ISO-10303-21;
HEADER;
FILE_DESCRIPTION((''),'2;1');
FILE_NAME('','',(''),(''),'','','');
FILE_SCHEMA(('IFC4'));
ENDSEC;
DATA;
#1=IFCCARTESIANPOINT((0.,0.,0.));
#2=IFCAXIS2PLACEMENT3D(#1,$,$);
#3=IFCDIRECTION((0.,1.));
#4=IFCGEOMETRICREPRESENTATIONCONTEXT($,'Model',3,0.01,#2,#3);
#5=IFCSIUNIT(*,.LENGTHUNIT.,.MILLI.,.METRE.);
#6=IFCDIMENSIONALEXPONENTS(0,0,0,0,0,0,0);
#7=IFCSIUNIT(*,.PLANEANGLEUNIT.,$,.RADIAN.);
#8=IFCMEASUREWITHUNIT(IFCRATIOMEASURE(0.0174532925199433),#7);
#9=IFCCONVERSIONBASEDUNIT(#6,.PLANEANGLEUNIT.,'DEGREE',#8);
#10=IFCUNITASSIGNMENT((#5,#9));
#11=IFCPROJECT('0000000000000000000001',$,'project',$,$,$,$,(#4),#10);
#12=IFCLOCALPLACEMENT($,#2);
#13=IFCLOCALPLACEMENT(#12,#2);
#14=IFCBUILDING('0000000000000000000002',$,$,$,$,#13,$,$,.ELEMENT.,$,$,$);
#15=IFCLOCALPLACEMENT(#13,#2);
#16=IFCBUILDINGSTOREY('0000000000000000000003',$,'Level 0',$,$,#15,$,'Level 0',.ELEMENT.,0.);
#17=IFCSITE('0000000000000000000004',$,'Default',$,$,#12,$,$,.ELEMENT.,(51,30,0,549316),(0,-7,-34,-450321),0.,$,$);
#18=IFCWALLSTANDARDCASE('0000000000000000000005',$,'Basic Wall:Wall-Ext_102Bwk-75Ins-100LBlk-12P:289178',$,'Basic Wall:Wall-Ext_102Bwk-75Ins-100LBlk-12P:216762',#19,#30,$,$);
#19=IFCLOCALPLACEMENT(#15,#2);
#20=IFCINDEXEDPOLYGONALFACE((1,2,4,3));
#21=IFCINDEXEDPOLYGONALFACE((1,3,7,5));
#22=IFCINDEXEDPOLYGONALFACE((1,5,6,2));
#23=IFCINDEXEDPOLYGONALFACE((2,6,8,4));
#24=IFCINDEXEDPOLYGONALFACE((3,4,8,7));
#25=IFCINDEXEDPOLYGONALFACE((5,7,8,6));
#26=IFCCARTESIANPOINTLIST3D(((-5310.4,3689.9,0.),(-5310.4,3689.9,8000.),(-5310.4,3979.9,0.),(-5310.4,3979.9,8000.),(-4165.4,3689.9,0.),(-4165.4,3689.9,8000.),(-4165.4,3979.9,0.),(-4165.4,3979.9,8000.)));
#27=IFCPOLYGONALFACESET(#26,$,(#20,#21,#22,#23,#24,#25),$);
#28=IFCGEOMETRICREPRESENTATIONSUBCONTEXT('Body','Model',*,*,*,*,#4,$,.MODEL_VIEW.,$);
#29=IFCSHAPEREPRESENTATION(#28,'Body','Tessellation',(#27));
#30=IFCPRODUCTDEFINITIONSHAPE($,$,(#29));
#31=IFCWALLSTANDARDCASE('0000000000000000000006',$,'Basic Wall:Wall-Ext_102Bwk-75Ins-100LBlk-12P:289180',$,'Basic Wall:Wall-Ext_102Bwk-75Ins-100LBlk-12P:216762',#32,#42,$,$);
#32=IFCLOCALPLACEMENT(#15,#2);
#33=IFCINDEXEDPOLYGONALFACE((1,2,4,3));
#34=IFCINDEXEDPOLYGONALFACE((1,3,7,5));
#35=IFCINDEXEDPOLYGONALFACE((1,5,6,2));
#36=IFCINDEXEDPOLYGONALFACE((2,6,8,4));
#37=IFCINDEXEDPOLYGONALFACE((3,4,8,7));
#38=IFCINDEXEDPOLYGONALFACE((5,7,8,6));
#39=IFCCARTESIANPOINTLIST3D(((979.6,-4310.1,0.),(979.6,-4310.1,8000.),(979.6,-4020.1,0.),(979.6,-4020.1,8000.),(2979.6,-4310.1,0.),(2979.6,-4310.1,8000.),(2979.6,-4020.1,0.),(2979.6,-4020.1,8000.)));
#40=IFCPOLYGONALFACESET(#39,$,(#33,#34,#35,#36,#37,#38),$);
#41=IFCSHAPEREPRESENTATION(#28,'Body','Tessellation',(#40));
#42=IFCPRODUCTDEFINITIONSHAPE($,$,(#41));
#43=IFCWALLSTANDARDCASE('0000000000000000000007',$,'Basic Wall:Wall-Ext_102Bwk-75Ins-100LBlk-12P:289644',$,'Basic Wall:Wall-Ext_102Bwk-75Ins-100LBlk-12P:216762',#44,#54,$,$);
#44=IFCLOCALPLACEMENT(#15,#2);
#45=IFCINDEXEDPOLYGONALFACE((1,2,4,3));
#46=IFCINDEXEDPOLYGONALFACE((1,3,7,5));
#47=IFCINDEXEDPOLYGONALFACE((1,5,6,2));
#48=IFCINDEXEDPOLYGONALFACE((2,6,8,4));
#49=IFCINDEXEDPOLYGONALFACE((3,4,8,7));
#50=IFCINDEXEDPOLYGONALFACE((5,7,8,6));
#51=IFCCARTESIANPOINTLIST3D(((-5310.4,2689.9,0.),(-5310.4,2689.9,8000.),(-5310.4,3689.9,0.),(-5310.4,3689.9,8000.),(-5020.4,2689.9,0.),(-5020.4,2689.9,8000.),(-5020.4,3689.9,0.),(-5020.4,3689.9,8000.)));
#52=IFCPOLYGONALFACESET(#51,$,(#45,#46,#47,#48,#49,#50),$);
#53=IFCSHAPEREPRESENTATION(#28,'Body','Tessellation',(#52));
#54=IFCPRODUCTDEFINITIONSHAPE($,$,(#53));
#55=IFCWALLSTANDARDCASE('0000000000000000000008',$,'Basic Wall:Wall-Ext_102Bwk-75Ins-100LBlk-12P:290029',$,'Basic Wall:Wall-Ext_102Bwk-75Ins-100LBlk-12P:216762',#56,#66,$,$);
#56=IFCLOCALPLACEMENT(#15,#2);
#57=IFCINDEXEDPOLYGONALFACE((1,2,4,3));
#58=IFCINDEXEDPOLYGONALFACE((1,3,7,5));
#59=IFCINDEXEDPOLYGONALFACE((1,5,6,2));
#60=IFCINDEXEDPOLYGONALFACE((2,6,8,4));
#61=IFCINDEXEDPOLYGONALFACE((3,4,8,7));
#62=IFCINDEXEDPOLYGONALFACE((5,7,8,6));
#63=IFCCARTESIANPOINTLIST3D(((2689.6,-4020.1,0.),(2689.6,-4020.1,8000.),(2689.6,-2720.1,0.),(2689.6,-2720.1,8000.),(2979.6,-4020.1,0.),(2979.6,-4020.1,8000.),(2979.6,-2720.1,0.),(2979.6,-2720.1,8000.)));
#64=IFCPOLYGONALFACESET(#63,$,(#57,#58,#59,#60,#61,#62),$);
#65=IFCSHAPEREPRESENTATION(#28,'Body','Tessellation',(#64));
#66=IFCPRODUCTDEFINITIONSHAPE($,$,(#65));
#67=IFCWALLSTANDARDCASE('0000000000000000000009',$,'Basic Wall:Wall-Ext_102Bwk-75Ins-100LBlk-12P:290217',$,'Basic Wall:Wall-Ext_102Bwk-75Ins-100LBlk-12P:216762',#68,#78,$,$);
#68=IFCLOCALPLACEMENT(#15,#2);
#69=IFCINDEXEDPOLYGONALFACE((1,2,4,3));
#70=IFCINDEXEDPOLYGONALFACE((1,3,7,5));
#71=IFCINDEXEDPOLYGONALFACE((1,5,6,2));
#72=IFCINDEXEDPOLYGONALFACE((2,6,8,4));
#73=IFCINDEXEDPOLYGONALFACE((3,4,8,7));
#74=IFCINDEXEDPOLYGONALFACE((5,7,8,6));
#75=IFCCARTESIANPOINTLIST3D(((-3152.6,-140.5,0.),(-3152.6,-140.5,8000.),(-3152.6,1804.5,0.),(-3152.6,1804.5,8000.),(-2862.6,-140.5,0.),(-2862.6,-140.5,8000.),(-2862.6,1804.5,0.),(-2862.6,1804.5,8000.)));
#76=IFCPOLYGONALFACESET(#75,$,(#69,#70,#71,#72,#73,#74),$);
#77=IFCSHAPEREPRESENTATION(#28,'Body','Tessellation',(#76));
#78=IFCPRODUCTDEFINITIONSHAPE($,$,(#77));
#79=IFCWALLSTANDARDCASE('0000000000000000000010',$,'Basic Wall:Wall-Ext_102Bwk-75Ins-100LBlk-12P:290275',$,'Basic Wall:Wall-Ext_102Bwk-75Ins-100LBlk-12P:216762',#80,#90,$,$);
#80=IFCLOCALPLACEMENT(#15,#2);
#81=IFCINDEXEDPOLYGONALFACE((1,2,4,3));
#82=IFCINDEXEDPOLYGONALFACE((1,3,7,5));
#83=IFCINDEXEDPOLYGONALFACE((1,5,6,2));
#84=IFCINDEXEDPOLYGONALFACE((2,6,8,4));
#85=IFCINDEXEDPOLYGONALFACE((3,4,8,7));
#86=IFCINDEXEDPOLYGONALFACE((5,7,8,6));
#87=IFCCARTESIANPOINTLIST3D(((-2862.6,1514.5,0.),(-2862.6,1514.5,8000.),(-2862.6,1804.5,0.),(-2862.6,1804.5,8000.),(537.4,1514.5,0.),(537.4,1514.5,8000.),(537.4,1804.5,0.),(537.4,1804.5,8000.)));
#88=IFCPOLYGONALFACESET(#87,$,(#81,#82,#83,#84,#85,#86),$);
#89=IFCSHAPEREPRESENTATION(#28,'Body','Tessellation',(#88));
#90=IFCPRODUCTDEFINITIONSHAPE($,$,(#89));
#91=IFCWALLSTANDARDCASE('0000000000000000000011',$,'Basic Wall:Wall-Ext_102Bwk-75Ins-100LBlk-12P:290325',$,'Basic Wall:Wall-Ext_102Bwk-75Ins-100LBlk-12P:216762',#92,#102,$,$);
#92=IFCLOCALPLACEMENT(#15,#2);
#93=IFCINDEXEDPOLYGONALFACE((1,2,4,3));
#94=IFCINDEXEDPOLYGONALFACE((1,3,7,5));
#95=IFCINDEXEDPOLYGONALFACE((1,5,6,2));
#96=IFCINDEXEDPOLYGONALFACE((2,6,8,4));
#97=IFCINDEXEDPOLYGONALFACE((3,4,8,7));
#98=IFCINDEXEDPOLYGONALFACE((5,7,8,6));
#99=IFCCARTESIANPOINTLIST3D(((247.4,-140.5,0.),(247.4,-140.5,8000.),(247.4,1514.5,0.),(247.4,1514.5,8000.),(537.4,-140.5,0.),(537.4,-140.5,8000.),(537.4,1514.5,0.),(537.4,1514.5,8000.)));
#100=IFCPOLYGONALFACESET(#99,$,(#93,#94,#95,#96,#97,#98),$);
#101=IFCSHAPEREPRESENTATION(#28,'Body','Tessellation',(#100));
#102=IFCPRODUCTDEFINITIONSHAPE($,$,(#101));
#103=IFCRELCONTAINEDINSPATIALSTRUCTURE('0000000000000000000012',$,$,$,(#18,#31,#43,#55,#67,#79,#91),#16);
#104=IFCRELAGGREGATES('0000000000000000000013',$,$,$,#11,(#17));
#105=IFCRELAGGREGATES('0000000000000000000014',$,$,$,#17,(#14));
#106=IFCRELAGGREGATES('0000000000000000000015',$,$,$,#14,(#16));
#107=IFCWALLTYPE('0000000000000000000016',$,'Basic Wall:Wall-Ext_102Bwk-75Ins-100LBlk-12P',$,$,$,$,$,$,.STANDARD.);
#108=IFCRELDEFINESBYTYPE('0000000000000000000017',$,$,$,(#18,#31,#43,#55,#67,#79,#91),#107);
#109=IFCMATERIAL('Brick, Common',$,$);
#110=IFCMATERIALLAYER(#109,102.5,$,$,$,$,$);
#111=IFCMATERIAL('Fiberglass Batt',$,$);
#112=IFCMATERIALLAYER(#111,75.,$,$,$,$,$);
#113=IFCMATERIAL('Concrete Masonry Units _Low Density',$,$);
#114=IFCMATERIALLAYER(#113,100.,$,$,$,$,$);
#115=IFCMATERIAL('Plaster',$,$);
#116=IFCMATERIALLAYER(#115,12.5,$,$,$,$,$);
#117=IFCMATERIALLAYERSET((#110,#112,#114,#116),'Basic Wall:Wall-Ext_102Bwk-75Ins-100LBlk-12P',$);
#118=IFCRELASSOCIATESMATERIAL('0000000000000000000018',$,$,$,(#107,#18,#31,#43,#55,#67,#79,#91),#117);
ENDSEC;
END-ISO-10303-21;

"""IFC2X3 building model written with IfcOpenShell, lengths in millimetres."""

from ifc_helpers import new_model, entity, si_unit, converted_unit, direction, frame, frame_2d, origin, place, context, subcontext, project, spatial, rectangle, extrude, material, layer, layer_set, layer_usage, type_object, element, save


model = new_model("IFC2X3")

# Units and contexts
model_context = context("Model", 3, precision=0.01, world=origin(), true_north=direction((0.0, 1.0)))
body_context = subcontext(model_context, "Body", "Model", "MODEL_VIEW")
ifc_project = project(units=[si_unit("LENGTHUNIT", "METRE", prefix="MILLI"), converted_unit("PLANEANGLEUNIT", "DEGREE", entity("IfcRatioMeasure", 0.0174532925199433), si_unit("PLANEANGLEUNIT", "RADIAN"), dimensions=[0, 0, 0, 0, 0, 0, 0])], contexts=[model_context])

# Site, building, storey
site_placement = place(None, origin())
site = spatial("IfcSite", under=ifc_project, at=site_placement, Name="Default", CompositionType="ELEMENT", RefLatitude=(51, 30, 0, 549316), RefLongitude=(0, -7, -34, -450321), RefElevation=0.0)
building_placement = place(site_placement, origin())
building = spatial("IfcBuilding", under=site, at=building_placement, CompositionType="ELEMENT")
storey_placement = place(building_placement, origin())
storey = spatial("IfcBuildingStorey", under=building, at=storey_placement, Name="Level 0", LongName="Level 0", CompositionType="ELEMENT", Elevation=0.0)

# Walls
ifc_material_1 = material(Name="Brick, Common")
ifc_layer_1 = layer(ifc_material_1, 102.5)
ifc_material_2 = material(Name="Fiberglass Batt")
ifc_layer_2 = layer(ifc_material_2, 75.0)
ifc_material_3 = material(Name="Concrete Masonry Units _Low Density")
ifc_layer_3 = layer(ifc_material_3, 100.0)
ifc_material_4 = material(Name="Plaster")
ifc_layer_4 = layer(ifc_material_4, 12.5)
ifc_layer_set = layer_set([ifc_layer_1, ifc_layer_2, ifc_layer_3, ifc_layer_4], Name="Basic Wall:Wall-Ext_102Bwk-75Ins-100LBlk-12P")
ifc_layer_usage_1 = layer_usage(ifc_layer_set, "AXIS2", "NEGATIVE", 145.0)
wall_type = type_object("IfcWallType", Name="Basic Wall:Wall-Ext_102Bwk-75Ins-100LBlk-12P", PredefinedType="STANDARD", material=ifc_layer_set)
wall_1_placement = place(storey_placement, frame((-5310.4, 3834.9, 0.0)))
element("IfcWallStandardCase", 1, at=wall_1_placement, inside=storey, type_object=wall_type, material=ifc_layer_usage_1, Name="Basic Wall:Wall-Ext_102Bwk-75Ins-100LBlk-12P:289178", ObjectType="Basic Wall:Wall-Ext_102Bwk-75Ins-100LBlk-12P:216762", context=body_context, shape_type="SweptSolid", body=[
    extrude(rectangle(XDim=1145.0, YDim=290.0, at=frame_2d((572.5, 0.0), x_axis=(-1.0, 0.0))), origin(), (0.0, 0.0, 1.0), 8000.0),
])
ifc_layer_usage_2 = layer_usage(ifc_layer_set, "AXIS2", "NEGATIVE", 145.0)
wall_2_placement = place(storey_placement, frame((2979.6, -4165.1, 0.0), z_axis=(0.0, 0.0, 1.0), x_axis=(-1.0, 0.0, 0.0)))
element("IfcWallStandardCase", 2, at=wall_2_placement, inside=storey, type_object=wall_type, material=ifc_layer_usage_2, Name="Basic Wall:Wall-Ext_102Bwk-75Ins-100LBlk-12P:289180", ObjectType="Basic Wall:Wall-Ext_102Bwk-75Ins-100LBlk-12P:216762", context=body_context, shape_type="SweptSolid", body=[
    extrude(rectangle(XDim=2000.0, YDim=290.0, at=frame_2d((1000.0, 0.0), x_axis=(-1.0, 0.0))), origin(), (0.0, 0.0, 1.0), 8000.0),
])
ifc_layer_usage_3 = layer_usage(ifc_layer_set, "AXIS2", "NEGATIVE", 145.0)
wall_3_placement = place(storey_placement, frame((-5165.4, 2689.9, 0.0), z_axis=(0.0, 0.0, 1.0), x_axis=(0.0, 1.0, 0.0)))
element("IfcWallStandardCase", 3, at=wall_3_placement, inside=storey, type_object=wall_type, material=ifc_layer_usage_3, Name="Basic Wall:Wall-Ext_102Bwk-75Ins-100LBlk-12P:289644", ObjectType="Basic Wall:Wall-Ext_102Bwk-75Ins-100LBlk-12P:216762", context=body_context, shape_type="SweptSolid", body=[
    extrude(rectangle(XDim=1000.0, YDim=290.0, at=frame_2d((500.0, 0.0), x_axis=(-1.0, 0.0))), origin(), (0.0, 0.0, 1.0), 8000.0),
])
ifc_layer_usage_4 = layer_usage(ifc_layer_set, "AXIS2", "NEGATIVE", 145.0)
wall_4_placement = place(storey_placement, frame((2834.6, -2720.1, 0.0), z_axis=(0.0, 0.0, 1.0), x_axis=(0.0, -1.0, 0.0)))
element("IfcWallStandardCase", 4, at=wall_4_placement, inside=storey, type_object=wall_type, material=ifc_layer_usage_4, Name="Basic Wall:Wall-Ext_102Bwk-75Ins-100LBlk-12P:290029", ObjectType="Basic Wall:Wall-Ext_102Bwk-75Ins-100LBlk-12P:216762", context=body_context, shape_type="SweptSolid", body=[
    extrude(rectangle(XDim=1300.0, YDim=290.0, at=frame_2d((650.0, 0.0), x_axis=(-1.0, 0.0))), origin(), (0.0, 0.0, 1.0), 8000.0),
])
ifc_layer_usage_5 = layer_usage(ifc_layer_set, "AXIS2", "NEGATIVE", 145.0)
wall_5_placement = place(storey_placement, frame((-3007.6, -140.5, 0.0), z_axis=(0.0, 0.0, 1.0), x_axis=(0.0, 1.0, 0.0)))
element("IfcWallStandardCase", 5, at=wall_5_placement, inside=storey, type_object=wall_type, material=ifc_layer_usage_5, Name="Basic Wall:Wall-Ext_102Bwk-75Ins-100LBlk-12P:290217", ObjectType="Basic Wall:Wall-Ext_102Bwk-75Ins-100LBlk-12P:216762", context=body_context, shape_type="SweptSolid", body=[
    extrude(rectangle(XDim=1945.0, YDim=290.0, at=frame_2d((972.5, 0.0), x_axis=(-1.0, 0.0))), origin(), (0.0, 0.0, 1.0), 8000.0),
])
ifc_layer_usage_6 = layer_usage(ifc_layer_set, "AXIS2", "NEGATIVE", 145.0)
wall_6_placement = place(storey_placement, frame((-2862.6, 1659.5, 0.0)))
element("IfcWallStandardCase", 6, at=wall_6_placement, inside=storey, type_object=wall_type, material=ifc_layer_usage_6, Name="Basic Wall:Wall-Ext_102Bwk-75Ins-100LBlk-12P:290275", ObjectType="Basic Wall:Wall-Ext_102Bwk-75Ins-100LBlk-12P:216762", context=body_context, shape_type="SweptSolid", body=[
    extrude(rectangle(XDim=3400.0, YDim=290.0, at=frame_2d((1700.0, 0.0), x_axis=(-1.0, 0.0))), origin(), (0.0, 0.0, 1.0), 8000.0),
])
ifc_layer_usage_7 = layer_usage(ifc_layer_set, "AXIS2", "NEGATIVE", 145.0)
wall_7_placement = place(storey_placement, frame((392.4, 1514.5, 0.0), z_axis=(0.0, 0.0, 1.0), x_axis=(0.0, -1.0, 0.0)))
element("IfcWallStandardCase", 7, at=wall_7_placement, inside=storey, type_object=wall_type, material=ifc_layer_usage_7, Name="Basic Wall:Wall-Ext_102Bwk-75Ins-100LBlk-12P:290325", ObjectType="Basic Wall:Wall-Ext_102Bwk-75Ins-100LBlk-12P:216762", context=body_context, shape_type="SweptSolid", body=[
    extrude(rectangle(XDim=1655.0, YDim=290.0, at=frame_2d((827.5, 0.0), x_axis=(-1.0, 0.0))), origin(), (0.0, 0.0, 1.0), 8000.0),
])

save(model, "model.ifc")
